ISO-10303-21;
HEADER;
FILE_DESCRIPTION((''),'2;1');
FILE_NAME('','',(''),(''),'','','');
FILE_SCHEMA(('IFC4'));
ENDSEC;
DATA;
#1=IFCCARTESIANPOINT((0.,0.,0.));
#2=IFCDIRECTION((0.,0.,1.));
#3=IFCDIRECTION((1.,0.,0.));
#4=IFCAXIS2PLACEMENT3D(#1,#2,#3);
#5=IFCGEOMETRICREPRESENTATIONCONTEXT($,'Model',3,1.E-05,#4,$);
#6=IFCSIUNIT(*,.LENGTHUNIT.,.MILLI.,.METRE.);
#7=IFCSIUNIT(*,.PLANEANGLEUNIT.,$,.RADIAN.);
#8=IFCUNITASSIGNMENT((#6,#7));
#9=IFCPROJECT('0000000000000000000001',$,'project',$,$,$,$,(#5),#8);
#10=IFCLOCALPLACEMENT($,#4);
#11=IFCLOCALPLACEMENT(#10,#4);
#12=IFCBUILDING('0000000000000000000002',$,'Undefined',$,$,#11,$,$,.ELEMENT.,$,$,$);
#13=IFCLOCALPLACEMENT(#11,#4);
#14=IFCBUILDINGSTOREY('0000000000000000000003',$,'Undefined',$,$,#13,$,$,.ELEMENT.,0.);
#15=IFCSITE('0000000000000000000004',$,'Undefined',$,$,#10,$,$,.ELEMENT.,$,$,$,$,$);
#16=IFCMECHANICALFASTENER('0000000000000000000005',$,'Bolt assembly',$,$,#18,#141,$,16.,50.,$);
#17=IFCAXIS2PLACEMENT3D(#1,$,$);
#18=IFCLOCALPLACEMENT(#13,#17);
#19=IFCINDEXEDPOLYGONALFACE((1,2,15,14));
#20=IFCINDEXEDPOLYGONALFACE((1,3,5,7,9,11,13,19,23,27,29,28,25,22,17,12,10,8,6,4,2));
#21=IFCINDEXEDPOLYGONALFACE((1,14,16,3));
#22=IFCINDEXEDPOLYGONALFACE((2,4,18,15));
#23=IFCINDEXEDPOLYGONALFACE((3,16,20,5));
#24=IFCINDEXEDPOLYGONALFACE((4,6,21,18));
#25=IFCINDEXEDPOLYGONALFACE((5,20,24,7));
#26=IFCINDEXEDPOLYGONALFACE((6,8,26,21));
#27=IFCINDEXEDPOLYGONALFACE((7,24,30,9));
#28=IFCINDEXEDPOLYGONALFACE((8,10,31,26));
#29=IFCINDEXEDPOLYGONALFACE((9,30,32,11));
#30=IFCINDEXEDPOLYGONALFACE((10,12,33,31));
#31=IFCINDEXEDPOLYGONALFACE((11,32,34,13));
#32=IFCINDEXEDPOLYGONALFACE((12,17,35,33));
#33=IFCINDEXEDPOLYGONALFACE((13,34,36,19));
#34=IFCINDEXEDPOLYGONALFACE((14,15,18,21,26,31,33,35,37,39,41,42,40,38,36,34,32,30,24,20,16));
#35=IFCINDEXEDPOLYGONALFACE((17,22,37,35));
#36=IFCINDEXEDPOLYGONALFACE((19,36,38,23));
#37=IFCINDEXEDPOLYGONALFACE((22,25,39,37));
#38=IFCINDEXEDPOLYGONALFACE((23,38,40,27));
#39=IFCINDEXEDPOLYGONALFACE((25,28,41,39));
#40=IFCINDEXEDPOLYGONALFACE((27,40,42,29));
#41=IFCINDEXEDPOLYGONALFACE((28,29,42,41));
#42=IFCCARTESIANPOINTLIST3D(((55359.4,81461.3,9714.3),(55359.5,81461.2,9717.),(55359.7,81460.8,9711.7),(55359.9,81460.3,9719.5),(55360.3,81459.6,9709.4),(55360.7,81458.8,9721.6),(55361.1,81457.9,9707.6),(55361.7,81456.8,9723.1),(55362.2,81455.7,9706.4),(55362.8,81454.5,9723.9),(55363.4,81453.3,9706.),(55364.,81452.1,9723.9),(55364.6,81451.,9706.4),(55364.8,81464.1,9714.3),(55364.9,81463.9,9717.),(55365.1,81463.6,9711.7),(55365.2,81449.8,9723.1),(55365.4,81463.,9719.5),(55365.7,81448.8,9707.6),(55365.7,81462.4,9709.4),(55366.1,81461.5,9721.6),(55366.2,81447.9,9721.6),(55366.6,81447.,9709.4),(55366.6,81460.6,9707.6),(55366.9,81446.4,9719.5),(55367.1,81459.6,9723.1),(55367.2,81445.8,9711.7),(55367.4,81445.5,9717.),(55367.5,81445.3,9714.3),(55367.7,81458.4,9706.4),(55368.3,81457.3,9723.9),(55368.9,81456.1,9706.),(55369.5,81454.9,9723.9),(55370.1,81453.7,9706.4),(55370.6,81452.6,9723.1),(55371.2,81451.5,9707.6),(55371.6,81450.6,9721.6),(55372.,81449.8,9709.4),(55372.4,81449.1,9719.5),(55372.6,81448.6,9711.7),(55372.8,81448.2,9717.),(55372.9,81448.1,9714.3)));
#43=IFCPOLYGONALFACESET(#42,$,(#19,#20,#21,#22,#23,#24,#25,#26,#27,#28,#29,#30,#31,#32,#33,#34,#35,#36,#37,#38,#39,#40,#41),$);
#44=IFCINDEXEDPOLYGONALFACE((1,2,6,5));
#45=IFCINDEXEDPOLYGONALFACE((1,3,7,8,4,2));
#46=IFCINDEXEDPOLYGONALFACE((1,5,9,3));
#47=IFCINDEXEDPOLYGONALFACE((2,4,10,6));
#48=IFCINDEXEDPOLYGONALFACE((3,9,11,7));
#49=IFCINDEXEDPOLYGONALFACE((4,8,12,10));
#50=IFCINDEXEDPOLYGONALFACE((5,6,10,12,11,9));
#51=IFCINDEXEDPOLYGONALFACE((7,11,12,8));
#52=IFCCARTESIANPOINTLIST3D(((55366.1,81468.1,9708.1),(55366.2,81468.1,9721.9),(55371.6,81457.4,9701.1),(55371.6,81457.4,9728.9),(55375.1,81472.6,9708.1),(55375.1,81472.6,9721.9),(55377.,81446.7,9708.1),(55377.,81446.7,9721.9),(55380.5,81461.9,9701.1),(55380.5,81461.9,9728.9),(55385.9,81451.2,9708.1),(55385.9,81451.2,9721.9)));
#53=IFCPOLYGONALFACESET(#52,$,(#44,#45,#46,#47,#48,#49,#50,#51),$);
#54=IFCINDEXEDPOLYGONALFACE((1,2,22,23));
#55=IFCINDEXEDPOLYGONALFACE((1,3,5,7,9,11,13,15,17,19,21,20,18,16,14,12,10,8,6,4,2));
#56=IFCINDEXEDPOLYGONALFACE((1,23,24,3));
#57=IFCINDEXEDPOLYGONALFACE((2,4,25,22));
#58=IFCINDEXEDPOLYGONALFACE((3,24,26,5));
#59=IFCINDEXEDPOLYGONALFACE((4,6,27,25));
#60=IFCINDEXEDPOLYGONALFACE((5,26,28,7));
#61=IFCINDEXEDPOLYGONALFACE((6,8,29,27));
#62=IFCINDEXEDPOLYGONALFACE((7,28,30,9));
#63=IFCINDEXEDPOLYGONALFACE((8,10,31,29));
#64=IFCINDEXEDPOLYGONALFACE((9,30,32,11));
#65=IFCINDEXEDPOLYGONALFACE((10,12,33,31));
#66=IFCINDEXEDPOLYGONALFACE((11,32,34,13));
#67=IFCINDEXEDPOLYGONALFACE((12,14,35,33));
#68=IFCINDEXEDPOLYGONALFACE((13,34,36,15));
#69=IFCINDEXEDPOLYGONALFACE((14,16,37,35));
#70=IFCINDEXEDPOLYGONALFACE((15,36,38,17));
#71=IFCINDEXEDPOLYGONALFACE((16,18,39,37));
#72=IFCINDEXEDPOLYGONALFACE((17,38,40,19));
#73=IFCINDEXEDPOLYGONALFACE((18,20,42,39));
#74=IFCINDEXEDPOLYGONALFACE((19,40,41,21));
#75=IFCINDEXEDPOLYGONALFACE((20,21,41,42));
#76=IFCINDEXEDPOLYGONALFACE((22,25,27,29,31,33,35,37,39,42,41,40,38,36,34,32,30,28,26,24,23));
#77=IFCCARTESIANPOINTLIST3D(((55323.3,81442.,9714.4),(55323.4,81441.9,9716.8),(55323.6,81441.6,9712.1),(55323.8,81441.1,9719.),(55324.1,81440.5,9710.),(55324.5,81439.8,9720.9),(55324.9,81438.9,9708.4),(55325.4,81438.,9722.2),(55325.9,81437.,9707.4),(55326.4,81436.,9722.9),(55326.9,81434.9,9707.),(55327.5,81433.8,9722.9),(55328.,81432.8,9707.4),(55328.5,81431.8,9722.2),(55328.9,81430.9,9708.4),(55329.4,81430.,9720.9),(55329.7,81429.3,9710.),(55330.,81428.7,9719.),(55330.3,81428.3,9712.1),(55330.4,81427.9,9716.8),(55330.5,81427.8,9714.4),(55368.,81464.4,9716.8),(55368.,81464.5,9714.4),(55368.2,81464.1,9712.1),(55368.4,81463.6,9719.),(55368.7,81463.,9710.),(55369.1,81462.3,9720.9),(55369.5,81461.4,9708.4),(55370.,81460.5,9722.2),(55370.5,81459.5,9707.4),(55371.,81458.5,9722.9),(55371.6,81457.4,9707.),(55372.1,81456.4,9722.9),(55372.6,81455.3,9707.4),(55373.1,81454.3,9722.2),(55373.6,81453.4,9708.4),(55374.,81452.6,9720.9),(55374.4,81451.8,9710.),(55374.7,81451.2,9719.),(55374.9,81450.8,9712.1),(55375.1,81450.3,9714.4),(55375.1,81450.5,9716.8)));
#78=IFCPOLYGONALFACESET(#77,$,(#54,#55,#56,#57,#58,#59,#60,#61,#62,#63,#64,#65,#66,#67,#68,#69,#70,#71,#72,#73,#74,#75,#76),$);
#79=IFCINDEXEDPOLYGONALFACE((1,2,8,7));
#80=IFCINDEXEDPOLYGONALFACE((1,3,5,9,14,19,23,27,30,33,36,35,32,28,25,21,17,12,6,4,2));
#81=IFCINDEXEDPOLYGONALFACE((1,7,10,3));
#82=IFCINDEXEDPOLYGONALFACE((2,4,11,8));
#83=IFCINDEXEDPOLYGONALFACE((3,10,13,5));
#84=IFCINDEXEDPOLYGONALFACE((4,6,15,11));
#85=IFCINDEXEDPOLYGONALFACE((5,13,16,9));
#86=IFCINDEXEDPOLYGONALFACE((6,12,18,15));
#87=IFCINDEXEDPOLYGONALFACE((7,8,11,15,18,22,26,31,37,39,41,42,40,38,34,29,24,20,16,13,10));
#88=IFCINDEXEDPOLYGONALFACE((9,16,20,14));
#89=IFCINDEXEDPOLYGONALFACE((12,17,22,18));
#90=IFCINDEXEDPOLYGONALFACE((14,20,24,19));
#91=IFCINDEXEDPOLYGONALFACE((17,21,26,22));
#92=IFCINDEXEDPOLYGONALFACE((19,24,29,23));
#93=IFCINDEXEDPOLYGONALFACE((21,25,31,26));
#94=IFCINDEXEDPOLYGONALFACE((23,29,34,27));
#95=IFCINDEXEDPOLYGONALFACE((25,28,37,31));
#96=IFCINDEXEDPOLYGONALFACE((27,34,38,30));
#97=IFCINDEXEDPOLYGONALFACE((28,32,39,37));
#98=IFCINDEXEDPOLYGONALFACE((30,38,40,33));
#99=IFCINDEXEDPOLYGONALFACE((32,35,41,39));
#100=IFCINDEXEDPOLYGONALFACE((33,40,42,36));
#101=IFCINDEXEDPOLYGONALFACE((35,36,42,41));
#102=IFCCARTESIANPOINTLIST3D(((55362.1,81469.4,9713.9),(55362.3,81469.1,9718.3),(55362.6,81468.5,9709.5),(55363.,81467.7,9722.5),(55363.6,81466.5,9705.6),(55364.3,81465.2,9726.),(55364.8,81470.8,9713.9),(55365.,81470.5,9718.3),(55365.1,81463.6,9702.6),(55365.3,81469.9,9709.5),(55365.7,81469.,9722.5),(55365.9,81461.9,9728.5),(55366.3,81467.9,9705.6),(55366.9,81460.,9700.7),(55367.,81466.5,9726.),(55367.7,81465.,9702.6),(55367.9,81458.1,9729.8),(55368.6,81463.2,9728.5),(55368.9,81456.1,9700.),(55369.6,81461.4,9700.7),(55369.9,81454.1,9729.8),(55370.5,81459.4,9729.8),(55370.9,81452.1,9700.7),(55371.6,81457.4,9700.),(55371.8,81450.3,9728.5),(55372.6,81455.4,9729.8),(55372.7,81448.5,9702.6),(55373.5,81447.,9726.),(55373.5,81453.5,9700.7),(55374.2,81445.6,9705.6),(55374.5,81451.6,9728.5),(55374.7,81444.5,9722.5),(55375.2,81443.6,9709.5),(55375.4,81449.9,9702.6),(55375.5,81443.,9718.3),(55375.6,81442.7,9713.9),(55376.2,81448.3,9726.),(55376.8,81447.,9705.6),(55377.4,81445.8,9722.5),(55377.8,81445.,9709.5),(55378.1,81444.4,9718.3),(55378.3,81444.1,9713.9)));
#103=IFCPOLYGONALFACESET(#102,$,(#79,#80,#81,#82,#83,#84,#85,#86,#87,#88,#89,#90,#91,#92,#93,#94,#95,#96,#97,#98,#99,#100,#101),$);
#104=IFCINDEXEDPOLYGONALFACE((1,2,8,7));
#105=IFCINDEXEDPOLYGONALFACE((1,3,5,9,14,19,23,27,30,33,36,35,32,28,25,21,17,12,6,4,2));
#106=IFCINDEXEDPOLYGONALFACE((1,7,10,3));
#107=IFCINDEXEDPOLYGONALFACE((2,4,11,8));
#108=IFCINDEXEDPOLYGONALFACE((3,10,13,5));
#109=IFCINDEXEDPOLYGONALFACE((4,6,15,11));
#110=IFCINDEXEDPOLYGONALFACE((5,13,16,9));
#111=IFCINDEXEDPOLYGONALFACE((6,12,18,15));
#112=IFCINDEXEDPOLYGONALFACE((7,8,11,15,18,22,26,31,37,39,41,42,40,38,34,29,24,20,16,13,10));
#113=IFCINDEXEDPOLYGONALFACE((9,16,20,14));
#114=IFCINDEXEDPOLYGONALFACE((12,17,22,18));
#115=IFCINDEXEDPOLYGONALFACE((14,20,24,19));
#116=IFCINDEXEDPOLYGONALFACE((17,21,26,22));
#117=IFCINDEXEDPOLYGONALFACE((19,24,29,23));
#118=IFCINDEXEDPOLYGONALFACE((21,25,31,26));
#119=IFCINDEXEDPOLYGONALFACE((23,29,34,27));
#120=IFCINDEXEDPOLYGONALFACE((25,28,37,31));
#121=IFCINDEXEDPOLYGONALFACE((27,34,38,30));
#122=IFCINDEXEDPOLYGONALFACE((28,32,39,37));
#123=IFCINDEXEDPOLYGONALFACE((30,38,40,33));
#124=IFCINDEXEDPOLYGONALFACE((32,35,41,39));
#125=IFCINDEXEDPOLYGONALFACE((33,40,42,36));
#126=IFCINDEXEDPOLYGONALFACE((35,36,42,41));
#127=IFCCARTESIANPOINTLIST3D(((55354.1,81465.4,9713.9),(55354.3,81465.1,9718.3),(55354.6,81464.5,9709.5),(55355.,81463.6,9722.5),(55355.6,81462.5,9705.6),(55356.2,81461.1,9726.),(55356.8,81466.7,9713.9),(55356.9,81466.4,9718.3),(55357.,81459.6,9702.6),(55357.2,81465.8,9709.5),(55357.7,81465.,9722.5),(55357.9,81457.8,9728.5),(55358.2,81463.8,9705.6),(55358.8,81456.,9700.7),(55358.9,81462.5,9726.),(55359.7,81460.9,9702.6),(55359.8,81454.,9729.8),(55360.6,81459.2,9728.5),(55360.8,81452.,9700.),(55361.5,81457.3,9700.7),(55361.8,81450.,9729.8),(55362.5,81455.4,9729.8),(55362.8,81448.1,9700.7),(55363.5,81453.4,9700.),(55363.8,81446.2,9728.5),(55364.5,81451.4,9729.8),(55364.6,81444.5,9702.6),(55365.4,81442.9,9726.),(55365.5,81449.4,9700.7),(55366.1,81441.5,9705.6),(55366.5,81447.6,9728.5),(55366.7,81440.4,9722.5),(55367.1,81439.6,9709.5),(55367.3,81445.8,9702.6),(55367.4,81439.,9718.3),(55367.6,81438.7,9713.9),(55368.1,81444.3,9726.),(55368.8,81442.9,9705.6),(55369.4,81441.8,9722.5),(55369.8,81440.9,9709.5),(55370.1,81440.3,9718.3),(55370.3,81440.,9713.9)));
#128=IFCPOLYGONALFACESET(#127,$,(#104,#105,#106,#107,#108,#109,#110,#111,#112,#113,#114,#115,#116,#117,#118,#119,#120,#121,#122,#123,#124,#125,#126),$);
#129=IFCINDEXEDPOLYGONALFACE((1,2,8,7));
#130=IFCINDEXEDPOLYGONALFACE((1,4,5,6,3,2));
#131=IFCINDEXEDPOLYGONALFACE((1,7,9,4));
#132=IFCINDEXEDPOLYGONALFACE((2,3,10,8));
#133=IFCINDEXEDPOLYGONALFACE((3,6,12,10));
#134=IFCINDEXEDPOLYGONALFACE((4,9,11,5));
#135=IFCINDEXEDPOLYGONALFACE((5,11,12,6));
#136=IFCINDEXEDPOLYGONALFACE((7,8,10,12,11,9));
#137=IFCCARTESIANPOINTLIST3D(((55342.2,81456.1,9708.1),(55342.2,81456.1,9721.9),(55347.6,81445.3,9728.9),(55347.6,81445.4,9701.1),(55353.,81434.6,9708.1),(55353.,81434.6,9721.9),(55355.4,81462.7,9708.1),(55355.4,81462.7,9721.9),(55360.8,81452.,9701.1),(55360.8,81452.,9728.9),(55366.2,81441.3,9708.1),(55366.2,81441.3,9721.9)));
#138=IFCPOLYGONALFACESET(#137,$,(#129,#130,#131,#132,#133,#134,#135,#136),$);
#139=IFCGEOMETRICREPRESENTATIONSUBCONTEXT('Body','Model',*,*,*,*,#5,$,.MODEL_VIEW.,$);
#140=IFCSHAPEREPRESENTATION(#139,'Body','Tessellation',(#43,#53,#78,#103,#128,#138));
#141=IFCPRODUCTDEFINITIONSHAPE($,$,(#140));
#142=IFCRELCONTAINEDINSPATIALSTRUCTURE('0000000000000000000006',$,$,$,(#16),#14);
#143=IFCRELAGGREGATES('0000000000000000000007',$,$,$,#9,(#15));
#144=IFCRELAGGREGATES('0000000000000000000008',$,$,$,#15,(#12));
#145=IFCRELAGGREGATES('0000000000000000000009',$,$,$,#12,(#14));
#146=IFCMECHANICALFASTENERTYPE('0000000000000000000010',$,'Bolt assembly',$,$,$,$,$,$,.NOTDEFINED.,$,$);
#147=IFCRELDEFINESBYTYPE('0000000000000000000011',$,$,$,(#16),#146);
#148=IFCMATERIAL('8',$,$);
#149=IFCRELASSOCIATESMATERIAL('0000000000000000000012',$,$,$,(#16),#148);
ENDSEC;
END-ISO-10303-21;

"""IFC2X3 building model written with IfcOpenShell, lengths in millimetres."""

from ifc_helpers import new_model, si_unit, frame, origin_with_axes, origin_2d_with_axis, place, context, subcontext, project, spatial, polyline, circle, outline, extrude, source, transform, mapped, material, type_object, element, save


model = new_model("IFC2X3")

# Units and contexts
model_context = context("Model", 3, precision=1e-05, world=origin_with_axes())
body_context = subcontext(model_context, "Body", "Model", "MODEL_VIEW")
ifc_project = project(units=[si_unit("LENGTHUNIT", "METRE", prefix="MILLI"), si_unit("PLANEANGLEUNIT", "RADIAN")], contexts=[model_context])

# Site, building, storey
site_placement = place(None, origin_with_axes())
site = spatial("IfcSite", under=ifc_project, at=site_placement, Name="Undefined", CompositionType="ELEMENT")
building_placement = place(site_placement, origin_with_axes())
building = spatial("IfcBuilding", under=site, at=building_placement, Name="Undefined", CompositionType="ELEMENT")
storey_placement = place(building_placement, origin_with_axes())
storey = spatial("IfcBuildingStorey", under=building, at=storey_placement, Name="Undefined", CompositionType="ELEMENT", Elevation=0.0)

# Mechanical fastener
ifc_material_1 = material(Name="8")
mechanical_fastener_type = type_object("IfcMechanicalFastenerType", Name="Bolt assembly")
shared_shape_1 = source(origin_with_axes(), body_context, "Body", "SweptSolid", [
    extrude(circle(Radius=9.0, at=origin_2d_with_axis()), frame((0.0, 0.0, 0.0), z_axis=(0.0, 1.0, 0.0), x_axis=(1.0, 0.0, 0.0)), (0.0, 0.0, 1.0), 6.1),
    extrude(outline(polyline([(13.9, 0.0), (6.9, 12.0), (-6.9, 12.0), (-13.9, 0.0), (-6.9, -12.0), (6.9, -12.0), (13.9, 0.0)])), frame((0.0, -13.0, 0.0), z_axis=(0.0, 1.0, 0.0), x_axis=(1.0, 0.0, 0.0)), (0.0, 0.0, 1.0), 10.0),
    extrude(circle(Radius=8.0, at=origin_2d_with_axis()), frame((0.0, -3.0, 0.0), z_axis=(0.0, 1.0, 0.0), x_axis=(1.0, 0.0, 0.0)), (0.0, 0.0, 1.0), 50.0),
    extrude(circle(Radius=15.0, at=origin_2d_with_axis()), frame((0.0, -3.0, 0.0), z_axis=(0.0, 1.0, 0.0), x_axis=(1.0, 0.0, 0.0)), (0.0, 0.0, 1.0), 3.0),
    extrude(circle(Radius=15.0, at=origin_2d_with_axis()), frame((0.0, 6.0, 0.0), z_axis=(0.0, 1.0, 0.0), x_axis=(1.0, 0.0, 0.0)), (0.0, 0.0, 1.0), 3.0),
    extrude(outline(polyline([(13.9, 0.0), (6.9, 12.0), (-6.9, 12.0), (-13.9, 0.0), (-6.9, -12.0), (6.9, -12.0), (13.9, 0.0)])), frame((0.0, 9.0, 0.0), z_axis=(0.0, 1.0, 0.0), x_axis=(1.0, 0.0, 0.0)), (0.0, 0.0, 1.0), 14.8),
])
mechanical_fastener_1_placement = place(storey_placement, frame((55368.9, 81456.1, 9715.0), z_axis=(-0.45041, 0.892822, 0.000127), x_axis=(-0.000057, 0.000114, -1.0)))
element("IfcMechanicalFastener", 1, at=mechanical_fastener_1_placement, inside=storey, type_object=mechanical_fastener_type, material=ifc_material_1, Name="Bolt assembly", NominalDiameter=16.0, NominalLength=50.0, context=body_context, shape_type="MappedRepresentation", body=[
    mapped(shared_shape_1, transform((0.0, 0.0, 0.0))),
])

save(model, "model.ifc")
